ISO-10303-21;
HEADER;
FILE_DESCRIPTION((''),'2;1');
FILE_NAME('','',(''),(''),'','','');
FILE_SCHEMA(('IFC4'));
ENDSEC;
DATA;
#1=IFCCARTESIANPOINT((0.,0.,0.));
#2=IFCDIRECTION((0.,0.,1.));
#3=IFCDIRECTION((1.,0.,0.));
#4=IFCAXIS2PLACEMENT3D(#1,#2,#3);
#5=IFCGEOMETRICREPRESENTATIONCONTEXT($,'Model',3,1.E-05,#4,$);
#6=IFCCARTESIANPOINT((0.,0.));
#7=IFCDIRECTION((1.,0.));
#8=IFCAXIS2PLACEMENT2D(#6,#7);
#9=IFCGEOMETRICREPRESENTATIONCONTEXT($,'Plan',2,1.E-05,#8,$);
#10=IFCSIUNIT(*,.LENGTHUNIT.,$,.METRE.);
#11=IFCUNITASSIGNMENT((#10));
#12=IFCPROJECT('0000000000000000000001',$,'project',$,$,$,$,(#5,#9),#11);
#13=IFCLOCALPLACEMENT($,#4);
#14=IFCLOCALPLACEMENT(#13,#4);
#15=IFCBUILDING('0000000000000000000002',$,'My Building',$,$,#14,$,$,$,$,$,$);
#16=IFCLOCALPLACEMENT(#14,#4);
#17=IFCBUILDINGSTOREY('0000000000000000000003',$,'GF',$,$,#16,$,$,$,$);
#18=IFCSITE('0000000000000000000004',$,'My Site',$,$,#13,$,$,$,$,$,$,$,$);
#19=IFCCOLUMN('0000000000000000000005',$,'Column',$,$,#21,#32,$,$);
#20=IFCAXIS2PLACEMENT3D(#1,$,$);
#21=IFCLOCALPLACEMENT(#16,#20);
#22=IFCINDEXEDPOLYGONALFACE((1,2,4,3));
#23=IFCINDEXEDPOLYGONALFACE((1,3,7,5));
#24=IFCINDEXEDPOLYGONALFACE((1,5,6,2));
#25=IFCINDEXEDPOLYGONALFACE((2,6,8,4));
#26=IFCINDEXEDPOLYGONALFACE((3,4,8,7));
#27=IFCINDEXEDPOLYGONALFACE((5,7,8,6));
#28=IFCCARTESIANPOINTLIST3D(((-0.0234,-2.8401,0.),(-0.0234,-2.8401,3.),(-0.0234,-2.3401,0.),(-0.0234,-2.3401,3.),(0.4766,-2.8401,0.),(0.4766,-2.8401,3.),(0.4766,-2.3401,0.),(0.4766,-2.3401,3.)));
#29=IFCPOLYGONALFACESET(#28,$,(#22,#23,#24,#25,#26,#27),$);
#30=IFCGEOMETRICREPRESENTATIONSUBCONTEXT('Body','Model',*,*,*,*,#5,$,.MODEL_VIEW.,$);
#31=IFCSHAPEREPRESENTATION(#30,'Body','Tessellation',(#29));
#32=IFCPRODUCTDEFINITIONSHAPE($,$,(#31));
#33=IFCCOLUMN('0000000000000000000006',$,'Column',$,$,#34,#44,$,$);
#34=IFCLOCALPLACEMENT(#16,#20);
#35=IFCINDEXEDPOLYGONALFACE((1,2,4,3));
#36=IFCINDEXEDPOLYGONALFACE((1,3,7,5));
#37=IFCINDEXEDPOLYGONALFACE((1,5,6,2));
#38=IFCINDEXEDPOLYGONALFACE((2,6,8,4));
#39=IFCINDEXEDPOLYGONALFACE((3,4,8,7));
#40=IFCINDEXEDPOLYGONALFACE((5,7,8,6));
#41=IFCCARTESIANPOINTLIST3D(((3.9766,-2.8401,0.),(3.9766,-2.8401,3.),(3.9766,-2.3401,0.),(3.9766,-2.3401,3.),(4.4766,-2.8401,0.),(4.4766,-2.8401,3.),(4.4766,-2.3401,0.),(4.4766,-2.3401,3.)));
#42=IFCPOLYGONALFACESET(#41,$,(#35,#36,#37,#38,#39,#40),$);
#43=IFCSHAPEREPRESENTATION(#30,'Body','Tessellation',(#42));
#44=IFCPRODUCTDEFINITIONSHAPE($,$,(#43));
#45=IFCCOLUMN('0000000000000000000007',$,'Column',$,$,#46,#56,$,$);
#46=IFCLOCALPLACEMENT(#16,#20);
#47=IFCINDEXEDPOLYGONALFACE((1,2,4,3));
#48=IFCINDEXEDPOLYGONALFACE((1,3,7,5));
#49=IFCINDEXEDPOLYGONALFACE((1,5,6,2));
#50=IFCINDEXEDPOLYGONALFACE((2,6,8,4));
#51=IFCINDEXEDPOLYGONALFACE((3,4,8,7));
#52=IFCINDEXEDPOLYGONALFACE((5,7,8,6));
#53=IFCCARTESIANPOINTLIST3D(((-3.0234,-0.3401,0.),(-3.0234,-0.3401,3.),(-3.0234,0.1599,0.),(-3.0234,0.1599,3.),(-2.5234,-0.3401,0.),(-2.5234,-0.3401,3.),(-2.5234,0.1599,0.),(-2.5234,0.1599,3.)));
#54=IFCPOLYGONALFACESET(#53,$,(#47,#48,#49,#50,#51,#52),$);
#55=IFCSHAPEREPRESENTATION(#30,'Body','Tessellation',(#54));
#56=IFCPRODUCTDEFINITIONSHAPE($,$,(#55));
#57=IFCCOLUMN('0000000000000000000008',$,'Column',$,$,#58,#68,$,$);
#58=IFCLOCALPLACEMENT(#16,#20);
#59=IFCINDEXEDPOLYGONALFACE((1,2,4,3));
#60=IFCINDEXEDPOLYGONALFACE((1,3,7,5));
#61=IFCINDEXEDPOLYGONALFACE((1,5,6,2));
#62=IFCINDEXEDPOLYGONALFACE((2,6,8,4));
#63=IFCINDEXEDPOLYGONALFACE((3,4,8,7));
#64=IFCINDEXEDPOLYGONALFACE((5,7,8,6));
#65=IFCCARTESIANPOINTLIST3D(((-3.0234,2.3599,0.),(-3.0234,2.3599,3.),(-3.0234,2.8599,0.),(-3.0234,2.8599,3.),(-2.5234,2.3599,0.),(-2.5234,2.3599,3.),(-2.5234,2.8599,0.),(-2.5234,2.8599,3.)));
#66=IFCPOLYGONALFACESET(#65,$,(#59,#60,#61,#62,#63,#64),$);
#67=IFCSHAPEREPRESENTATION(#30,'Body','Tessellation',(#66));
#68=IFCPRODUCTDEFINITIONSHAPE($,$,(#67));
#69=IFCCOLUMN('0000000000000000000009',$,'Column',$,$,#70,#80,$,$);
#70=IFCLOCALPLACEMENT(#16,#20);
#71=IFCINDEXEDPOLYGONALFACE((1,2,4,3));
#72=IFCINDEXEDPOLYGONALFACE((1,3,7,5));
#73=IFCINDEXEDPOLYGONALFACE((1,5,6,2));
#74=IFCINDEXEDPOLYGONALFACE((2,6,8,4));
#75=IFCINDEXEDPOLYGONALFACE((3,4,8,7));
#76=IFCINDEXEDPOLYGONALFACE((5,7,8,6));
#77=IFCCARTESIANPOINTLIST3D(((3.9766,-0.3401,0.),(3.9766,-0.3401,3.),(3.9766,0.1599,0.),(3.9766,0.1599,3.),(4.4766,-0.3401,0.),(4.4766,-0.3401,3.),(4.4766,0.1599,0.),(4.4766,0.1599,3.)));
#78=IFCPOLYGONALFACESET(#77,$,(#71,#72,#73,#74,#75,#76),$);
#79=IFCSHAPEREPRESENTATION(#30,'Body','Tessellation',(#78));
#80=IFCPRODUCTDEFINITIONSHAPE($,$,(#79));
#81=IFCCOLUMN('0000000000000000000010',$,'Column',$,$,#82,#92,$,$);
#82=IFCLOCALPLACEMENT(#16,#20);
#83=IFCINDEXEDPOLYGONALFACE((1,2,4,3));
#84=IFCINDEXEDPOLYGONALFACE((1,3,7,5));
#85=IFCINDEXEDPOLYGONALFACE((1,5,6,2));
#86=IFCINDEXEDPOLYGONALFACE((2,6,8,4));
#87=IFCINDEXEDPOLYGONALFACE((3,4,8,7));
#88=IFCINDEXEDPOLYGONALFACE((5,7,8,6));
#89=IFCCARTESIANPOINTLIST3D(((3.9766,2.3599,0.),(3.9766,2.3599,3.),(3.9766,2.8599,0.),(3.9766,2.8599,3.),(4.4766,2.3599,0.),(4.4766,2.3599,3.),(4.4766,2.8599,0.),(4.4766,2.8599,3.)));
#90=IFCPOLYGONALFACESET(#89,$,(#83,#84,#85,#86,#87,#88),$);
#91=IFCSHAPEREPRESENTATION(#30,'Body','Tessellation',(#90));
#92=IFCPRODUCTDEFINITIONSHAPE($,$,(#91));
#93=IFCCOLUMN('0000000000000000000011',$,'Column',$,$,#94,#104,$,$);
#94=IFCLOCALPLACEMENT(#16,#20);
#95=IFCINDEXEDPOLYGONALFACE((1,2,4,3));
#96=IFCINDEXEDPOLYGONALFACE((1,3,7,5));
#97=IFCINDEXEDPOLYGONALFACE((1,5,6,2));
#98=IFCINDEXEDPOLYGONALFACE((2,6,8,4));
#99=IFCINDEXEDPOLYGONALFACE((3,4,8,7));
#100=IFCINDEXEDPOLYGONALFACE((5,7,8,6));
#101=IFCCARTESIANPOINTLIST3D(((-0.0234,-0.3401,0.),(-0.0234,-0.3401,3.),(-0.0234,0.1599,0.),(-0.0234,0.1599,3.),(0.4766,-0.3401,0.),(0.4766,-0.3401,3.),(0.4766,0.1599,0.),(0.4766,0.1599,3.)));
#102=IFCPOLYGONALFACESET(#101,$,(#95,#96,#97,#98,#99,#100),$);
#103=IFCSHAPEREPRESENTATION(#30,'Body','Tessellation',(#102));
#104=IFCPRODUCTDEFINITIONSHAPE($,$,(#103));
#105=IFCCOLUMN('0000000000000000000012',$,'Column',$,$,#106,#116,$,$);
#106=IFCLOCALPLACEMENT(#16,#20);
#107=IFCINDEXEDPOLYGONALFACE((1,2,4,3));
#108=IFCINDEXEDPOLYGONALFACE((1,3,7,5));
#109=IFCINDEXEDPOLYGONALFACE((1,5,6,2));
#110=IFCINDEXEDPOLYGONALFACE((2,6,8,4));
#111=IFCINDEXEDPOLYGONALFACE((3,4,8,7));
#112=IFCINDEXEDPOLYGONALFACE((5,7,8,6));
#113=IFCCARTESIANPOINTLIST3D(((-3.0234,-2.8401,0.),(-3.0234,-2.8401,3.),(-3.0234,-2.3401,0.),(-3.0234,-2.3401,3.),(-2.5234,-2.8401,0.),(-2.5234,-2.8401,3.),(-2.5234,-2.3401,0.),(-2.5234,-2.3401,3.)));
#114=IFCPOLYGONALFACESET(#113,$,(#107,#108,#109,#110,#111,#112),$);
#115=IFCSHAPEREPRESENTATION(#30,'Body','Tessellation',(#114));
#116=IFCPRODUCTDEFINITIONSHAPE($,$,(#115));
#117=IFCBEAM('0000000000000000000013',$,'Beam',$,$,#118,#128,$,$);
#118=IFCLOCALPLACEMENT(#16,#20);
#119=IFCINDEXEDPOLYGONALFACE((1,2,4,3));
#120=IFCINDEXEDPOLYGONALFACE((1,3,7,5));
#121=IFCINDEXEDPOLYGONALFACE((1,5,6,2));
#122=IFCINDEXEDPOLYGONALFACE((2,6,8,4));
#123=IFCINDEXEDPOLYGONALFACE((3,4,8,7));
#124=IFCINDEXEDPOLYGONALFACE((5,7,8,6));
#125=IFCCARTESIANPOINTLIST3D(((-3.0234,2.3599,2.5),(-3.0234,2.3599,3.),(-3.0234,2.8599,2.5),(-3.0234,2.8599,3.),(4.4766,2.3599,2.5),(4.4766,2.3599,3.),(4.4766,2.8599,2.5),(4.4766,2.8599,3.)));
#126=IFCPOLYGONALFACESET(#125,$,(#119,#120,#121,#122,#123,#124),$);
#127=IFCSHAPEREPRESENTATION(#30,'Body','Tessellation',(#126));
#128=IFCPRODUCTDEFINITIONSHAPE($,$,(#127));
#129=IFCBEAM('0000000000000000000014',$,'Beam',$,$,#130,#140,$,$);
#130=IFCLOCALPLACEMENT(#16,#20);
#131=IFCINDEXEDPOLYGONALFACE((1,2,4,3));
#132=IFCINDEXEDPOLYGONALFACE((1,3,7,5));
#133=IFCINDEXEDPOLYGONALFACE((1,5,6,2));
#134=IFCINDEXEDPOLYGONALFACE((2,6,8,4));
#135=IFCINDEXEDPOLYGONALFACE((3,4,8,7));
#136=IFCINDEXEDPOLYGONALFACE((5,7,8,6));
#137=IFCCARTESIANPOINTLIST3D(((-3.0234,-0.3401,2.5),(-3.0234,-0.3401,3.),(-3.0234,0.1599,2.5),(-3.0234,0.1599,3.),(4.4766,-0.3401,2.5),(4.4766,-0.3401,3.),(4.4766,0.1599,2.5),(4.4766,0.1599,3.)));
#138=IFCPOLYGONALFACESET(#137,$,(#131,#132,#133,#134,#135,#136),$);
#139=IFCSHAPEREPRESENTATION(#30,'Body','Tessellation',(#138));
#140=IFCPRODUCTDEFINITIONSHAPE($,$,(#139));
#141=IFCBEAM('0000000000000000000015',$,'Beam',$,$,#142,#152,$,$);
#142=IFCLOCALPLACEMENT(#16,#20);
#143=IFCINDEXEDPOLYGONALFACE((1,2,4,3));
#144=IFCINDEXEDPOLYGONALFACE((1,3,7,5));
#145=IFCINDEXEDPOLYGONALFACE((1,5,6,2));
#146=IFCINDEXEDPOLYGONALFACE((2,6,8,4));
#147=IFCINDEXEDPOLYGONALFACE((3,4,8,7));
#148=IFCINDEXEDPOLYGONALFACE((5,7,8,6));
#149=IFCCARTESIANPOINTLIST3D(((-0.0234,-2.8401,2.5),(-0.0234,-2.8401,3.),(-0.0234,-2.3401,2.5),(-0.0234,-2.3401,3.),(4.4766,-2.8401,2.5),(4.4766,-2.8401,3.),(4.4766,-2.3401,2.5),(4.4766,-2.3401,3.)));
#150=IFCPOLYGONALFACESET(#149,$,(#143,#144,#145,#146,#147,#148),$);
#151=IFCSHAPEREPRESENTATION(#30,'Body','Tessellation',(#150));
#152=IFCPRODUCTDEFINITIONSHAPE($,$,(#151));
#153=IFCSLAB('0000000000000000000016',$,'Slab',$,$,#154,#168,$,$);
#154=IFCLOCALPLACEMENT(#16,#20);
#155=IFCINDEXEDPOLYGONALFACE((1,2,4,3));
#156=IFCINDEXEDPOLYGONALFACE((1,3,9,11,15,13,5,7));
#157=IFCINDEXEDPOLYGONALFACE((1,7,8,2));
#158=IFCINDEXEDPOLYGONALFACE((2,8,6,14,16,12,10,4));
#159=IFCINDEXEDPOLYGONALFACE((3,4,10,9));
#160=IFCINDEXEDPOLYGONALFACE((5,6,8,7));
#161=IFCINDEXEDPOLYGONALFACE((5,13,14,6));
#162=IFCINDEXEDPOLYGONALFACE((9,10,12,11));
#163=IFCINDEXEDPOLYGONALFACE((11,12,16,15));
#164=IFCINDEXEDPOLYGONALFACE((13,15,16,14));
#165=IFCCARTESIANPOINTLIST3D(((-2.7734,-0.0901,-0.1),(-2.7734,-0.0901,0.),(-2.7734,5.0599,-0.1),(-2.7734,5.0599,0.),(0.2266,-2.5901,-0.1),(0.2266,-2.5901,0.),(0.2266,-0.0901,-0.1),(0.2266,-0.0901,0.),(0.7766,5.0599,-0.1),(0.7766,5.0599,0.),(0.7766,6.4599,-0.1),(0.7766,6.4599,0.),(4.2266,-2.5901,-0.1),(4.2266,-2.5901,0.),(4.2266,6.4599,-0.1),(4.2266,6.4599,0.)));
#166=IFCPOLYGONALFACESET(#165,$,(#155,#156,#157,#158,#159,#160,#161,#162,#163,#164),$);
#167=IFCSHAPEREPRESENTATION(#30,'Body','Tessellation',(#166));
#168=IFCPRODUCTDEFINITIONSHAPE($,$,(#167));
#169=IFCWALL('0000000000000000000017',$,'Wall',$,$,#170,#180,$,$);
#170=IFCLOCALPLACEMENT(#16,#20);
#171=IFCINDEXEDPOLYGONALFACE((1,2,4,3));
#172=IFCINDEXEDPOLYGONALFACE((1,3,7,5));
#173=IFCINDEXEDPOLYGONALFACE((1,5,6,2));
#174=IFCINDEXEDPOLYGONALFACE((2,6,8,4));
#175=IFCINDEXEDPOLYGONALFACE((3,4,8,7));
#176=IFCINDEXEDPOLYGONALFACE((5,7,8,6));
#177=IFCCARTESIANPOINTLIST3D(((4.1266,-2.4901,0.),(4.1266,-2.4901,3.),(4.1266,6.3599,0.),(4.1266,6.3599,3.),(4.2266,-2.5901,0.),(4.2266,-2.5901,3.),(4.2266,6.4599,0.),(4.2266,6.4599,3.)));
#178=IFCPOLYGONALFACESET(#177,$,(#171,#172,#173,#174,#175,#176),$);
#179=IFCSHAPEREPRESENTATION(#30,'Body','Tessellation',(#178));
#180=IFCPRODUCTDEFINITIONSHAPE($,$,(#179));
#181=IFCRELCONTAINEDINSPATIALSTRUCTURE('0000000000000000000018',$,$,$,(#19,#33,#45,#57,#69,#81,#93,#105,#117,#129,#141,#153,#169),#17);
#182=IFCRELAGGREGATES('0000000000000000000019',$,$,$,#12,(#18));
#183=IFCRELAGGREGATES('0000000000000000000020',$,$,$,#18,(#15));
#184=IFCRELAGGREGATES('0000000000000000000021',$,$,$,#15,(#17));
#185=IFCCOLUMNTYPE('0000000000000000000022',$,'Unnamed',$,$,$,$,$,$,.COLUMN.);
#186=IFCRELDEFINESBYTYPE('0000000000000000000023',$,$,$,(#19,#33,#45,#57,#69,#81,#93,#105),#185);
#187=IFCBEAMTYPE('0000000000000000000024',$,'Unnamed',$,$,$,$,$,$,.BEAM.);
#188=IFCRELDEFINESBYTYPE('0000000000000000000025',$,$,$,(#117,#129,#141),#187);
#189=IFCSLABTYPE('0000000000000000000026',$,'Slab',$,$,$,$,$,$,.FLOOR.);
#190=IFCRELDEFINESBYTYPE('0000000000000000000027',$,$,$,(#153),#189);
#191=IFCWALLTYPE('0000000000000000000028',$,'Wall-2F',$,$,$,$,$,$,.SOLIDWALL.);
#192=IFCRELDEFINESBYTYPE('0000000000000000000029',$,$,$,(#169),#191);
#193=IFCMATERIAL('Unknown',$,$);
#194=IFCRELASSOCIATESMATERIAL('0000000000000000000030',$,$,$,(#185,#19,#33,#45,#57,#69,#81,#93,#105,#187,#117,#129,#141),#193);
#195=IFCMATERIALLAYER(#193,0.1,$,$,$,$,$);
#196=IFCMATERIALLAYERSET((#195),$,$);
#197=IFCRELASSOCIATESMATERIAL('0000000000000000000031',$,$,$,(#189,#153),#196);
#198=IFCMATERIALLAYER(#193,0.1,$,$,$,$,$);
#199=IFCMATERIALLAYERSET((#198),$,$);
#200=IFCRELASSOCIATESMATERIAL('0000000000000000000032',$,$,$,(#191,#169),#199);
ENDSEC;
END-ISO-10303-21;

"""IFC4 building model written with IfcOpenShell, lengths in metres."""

from ifc_helpers import new_model, si_unit, frame, origin_with_axes, origin_2d_with_axis, place, context, subcontext, project, spatial, line, indexed_curve, rectangle, outline, extrude, material, layer, layer_set, layer_usage, material_profile, profile_set, profile_usage, type_object, element, save


model = new_model("IFC4")

# Units and contexts
model_context = context("Model", 3, precision=1e-05, world=origin_with_axes())
plan_context = context("Plan", 2, precision=1e-05, world=origin_2d_with_axis())
body_context_1 = subcontext(model_context, "Body", "Model", "MODEL_VIEW")
ifc_project = project(units=[si_unit("LENGTHUNIT", "METRE")], contexts=[model_context, plan_context])

# Site, building, storey
site_placement = place(None, origin_with_axes())
site = spatial("IfcSite", under=ifc_project, at=site_placement, Name="My Site")
building_placement = place(site_placement, origin_with_axes())
building = spatial("IfcBuilding", under=site, at=building_placement, Name="My Building")
storey_placement = place(building_placement, origin_with_axes())
storey = spatial("IfcBuildingStorey", under=building, at=storey_placement, Name="GF")

# Columns
ifc_material = material(Name="Unknown")
ifc_material_profile_1 = material_profile(ifc_material, rectangle(XDim=0.5, YDim=0.5))
ifc_profile_set_1 = profile_set([ifc_material_profile_1])
ifc_profile_usage_1 = profile_usage(ifc_profile_set_1, cardinal=5)
column_type = type_object("IfcColumnType", Name="Unnamed", PredefinedType="COLUMN", material=ifc_profile_set_1)
column_1_placement = place(storey_placement, frame((0.2266, -2.5901, 0.0), z_axis=(0.0, 0.0, 1.0), x_axis=(1.0, 0.0, 0.0)))
element("IfcColumn", 1, at=column_1_placement, inside=storey, type_object=column_type, material=ifc_profile_usage_1, Name="Column", context=body_context_1, shape_type="SweptSolid", body=[
    extrude(rectangle(XDim=0.5, YDim=0.5), origin_with_axes(), (0.0, 0.0, 1.0), 3.0),
])
ifc_profile_usage_2 = profile_usage(ifc_profile_set_1, cardinal=5)
column_2_placement = place(storey_placement, frame((4.2266, -2.5901, 0.0), z_axis=(0.0, 0.0, 1.0), x_axis=(1.0, 0.0, 0.0)))
element("IfcColumn", 2, at=column_2_placement, inside=storey, type_object=column_type, material=ifc_profile_usage_2, Name="Column", context=body_context_1, shape_type="SweptSolid", body=[
    extrude(rectangle(XDim=0.5, YDim=0.5), origin_with_axes(), (0.0, 0.0, 1.0), 3.0),
])
ifc_profile_usage_3 = profile_usage(ifc_profile_set_1, cardinal=5)
column_3_placement = place(storey_placement, frame((-2.7734, -0.0901, 0.0), z_axis=(0.0, 0.0, 1.0), x_axis=(1.0, 0.0, 0.0)))
element("IfcColumn", 3, at=column_3_placement, inside=storey, type_object=column_type, material=ifc_profile_usage_3, Name="Column", context=body_context_1, shape_type="SweptSolid", body=[
    extrude(rectangle(XDim=0.5, YDim=0.5), origin_with_axes(), (0.0, 0.0, 1.0), 3.0),
])
ifc_profile_usage_4 = profile_usage(ifc_profile_set_1, cardinal=5)
column_4_placement = place(storey_placement, frame((-2.7734, 2.6099, 0.0), z_axis=(0.0, 0.0, 1.0), x_axis=(1.0, 0.0, 0.0)))
element("IfcColumn", 4, at=column_4_placement, inside=storey, type_object=column_type, material=ifc_profile_usage_4, Name="Column", context=body_context_1, shape_type="SweptSolid", body=[
    extrude(rectangle(XDim=0.5, YDim=0.5), origin_with_axes(), (0.0, 0.0, 1.0), 3.0),
])
ifc_profile_usage_5 = profile_usage(ifc_profile_set_1, cardinal=5)
column_5_placement = place(storey_placement, frame((4.2266, -0.0901, 0.0), z_axis=(0.0, 0.0, 1.0), x_axis=(1.0, 0.0, 0.0)))
element("IfcColumn", 5, at=column_5_placement, inside=storey, type_object=column_type, material=ifc_profile_usage_5, Name="Column", context=body_context_1, shape_type="SweptSolid", body=[
    extrude(rectangle(XDim=0.5, YDim=0.5), origin_with_axes(), (0.0, 0.0, 1.0), 3.0),
])
ifc_profile_usage_6 = profile_usage(ifc_profile_set_1, cardinal=5)
column_6_placement = place(storey_placement, frame((4.2266, 2.6099, 0.0), z_axis=(0.0, 0.0, 1.0), x_axis=(1.0, 0.0, 0.0)))
element("IfcColumn", 6, at=column_6_placement, inside=storey, type_object=column_type, material=ifc_profile_usage_6, Name="Column", context=body_context_1, shape_type="SweptSolid", body=[
    extrude(rectangle(XDim=0.5, YDim=0.5), origin_with_axes(), (0.0, 0.0, 1.0), 3.0),
])
ifc_profile_usage_7 = profile_usage(ifc_profile_set_1, cardinal=5)
column_7_placement = place(storey_placement, frame((0.2266, -0.0901, 0.0), z_axis=(0.0, 0.0, 1.0), x_axis=(1.0, 0.0, 0.0)))
element("IfcColumn", 7, at=column_7_placement, inside=storey, type_object=column_type, material=ifc_profile_usage_7, Name="Column", context=body_context_1, shape_type="SweptSolid", body=[
    extrude(rectangle(XDim=0.5, YDim=0.5), origin_with_axes(), (0.0, 0.0, 1.0), 3.0),
])
ifc_profile_usage_8 = profile_usage(ifc_profile_set_1, cardinal=5)
column_8_placement = place(storey_placement, frame((-2.7734, -2.5901, 0.0), z_axis=(0.0, 0.0, 1.0), x_axis=(1.0, 0.0, 0.0)))
element("IfcColumn", 8, at=column_8_placement, inside=storey, type_object=column_type, material=ifc_profile_usage_8, Name="Column", context=body_context_1, shape_type="SweptSolid", body=[
    extrude(rectangle(XDim=0.5, YDim=0.5), origin_with_axes(), (0.0, 0.0, 1.0), 3.0),
])

# Beams
ifc_material_profile_2 = material_profile(ifc_material, rectangle(XDim=0.5, YDim=0.5))
ifc_profile_set_2 = profile_set([ifc_material_profile_2])
ifc_profile_usage_9 = profile_usage(ifc_profile_set_2, cardinal=7)
beam_type = type_object("IfcBeamType", Name="Unnamed", PredefinedType="BEAM", material=ifc_profile_set_2)
beam_1_placement = place(storey_placement, frame((4.4766, 2.3599, 3.0), z_axis=(-1.0, 0.0, 0.0), x_axis=(0.0, -1.0, 0.0)))
element("IfcBeam", 9, at=beam_1_placement, inside=storey, type_object=beam_type, material=ifc_profile_usage_9, Name="Beam", context=body_context_1, shape_type="SweptSolid", body=[
    extrude(rectangle(XDim=0.5, YDim=0.5), frame((-0.25, -0.25, 0.0), z_axis=(0.0, 0.0, 1.0), x_axis=(1.0, 0.0, 0.0)), (0.0, 0.0, 1.0), 7.5),
])
ifc_profile_usage_10 = profile_usage(ifc_profile_set_2, cardinal=7)
beam_2_placement = place(storey_placement, frame((4.4766, -0.3401, 3.0), z_axis=(-1.0, 0.0, 0.0), x_axis=(0.0, -1.0, 0.0)))
element("IfcBeam", 10, at=beam_2_placement, inside=storey, type_object=beam_type, material=ifc_profile_usage_10, Name="Beam", context=body_context_1, shape_type="SweptSolid", body=[
    extrude(rectangle(XDim=0.5, YDim=0.5), frame((-0.25, -0.25, 0.0), z_axis=(0.0, 0.0, 1.0), x_axis=(1.0, 0.0, 0.0)), (0.0, 0.0, 1.0), 7.5),
])
ifc_profile_usage_11 = profile_usage(ifc_profile_set_2, cardinal=7)
beam_3_placement = place(storey_placement, frame((4.4766, -2.8401, 3.0), z_axis=(-1.0, -0.000001, 0.000001), x_axis=(0.000001, -1.0, 0.0)))
element("IfcBeam", 11, at=beam_3_placement, inside=storey, type_object=beam_type, material=ifc_profile_usage_11, Name="Beam", context=body_context_1, shape_type="SweptSolid", body=[
    extrude(rectangle(XDim=0.5, YDim=0.5), frame((-0.25, -0.25, 0.0), z_axis=(0.0, 0.0, 1.0), x_axis=(1.0, 0.0, 0.0)), (0.0, 0.0, 1.0), 4.5),
])

# Slab
ifc_layer_1 = layer(ifc_material, 0.1)
ifc_layer_set_1 = layer_set([ifc_layer_1])
ifc_layer_usage_1 = layer_usage(ifc_layer_set_1, "AXIS3", "POSITIVE", -0.1)
slab_type_1 = type_object("IfcSlabType", Name="Slab", PredefinedType="FLOOR", material=ifc_layer_set_1)
slab_1_placement = place(storey_placement, frame((4.2266, -2.5901, 0.0), z_axis=(0.0, 0.0, 1.0), x_axis=(1.0, 0.0, 0.0)))
element("IfcSlab", 12, at=slab_1_placement, inside=storey, type_object=slab_type_1, material=ifc_layer_usage_1, Name="Slab", context=body_context_1, shape_type="SweptSolid", body=[
    extrude(outline(indexed_curve([(0.0, 0.0), (0.0, 9.05), (-3.45, 9.05), (-3.45, 7.65), (-7.0, 7.65), (-7.0, 2.5), (-4.0, 2.5), (-4.0, 0.0), (0.0, 0.0)])), frame((0.0, 0.0, -0.1), z_axis=(0.0, 0.0, 1.0), x_axis=(1.0, 0.0, 0.0)), (0.0, 0.0, 1.0), 0.1),
])

# Shared definitions
ifc_layer_2 = layer(ifc_material, 0.1)
ifc_layer_set_2 = layer_set([ifc_layer_2])
wall_type = type_object("IfcWallType", Name="Wall-2F", PredefinedType="SOLIDWALL", material=ifc_layer_set_2)

# Wall
ifc_layer_usage_2 = layer_usage(ifc_layer_set_2, "AXIS2", "POSITIVE", 0.0)
wall_1_placement = place(storey_placement, frame((4.2266, -2.5901, 0.0), z_axis=(0.0, 0.0, 1.0), x_axis=(0.0, 1.0, 0.0)))
element("IfcWall", 13, at=wall_1_placement, inside=storey, type_object=wall_type, material=ifc_layer_usage_2, Name="Wall", context=body_context_1, shape_type="SweptSolid", body=[
    extrude(outline(indexed_curve([(0.0, 0.0), (0.1, 0.1), (8.95, 0.1), (9.05, 0.0)], segments=[line(1, 2, 3, 4, 1)])), origin_with_axes(), (0.0, 0.0, 1.0), 3.0),
])

save(model, "model.ifc")
